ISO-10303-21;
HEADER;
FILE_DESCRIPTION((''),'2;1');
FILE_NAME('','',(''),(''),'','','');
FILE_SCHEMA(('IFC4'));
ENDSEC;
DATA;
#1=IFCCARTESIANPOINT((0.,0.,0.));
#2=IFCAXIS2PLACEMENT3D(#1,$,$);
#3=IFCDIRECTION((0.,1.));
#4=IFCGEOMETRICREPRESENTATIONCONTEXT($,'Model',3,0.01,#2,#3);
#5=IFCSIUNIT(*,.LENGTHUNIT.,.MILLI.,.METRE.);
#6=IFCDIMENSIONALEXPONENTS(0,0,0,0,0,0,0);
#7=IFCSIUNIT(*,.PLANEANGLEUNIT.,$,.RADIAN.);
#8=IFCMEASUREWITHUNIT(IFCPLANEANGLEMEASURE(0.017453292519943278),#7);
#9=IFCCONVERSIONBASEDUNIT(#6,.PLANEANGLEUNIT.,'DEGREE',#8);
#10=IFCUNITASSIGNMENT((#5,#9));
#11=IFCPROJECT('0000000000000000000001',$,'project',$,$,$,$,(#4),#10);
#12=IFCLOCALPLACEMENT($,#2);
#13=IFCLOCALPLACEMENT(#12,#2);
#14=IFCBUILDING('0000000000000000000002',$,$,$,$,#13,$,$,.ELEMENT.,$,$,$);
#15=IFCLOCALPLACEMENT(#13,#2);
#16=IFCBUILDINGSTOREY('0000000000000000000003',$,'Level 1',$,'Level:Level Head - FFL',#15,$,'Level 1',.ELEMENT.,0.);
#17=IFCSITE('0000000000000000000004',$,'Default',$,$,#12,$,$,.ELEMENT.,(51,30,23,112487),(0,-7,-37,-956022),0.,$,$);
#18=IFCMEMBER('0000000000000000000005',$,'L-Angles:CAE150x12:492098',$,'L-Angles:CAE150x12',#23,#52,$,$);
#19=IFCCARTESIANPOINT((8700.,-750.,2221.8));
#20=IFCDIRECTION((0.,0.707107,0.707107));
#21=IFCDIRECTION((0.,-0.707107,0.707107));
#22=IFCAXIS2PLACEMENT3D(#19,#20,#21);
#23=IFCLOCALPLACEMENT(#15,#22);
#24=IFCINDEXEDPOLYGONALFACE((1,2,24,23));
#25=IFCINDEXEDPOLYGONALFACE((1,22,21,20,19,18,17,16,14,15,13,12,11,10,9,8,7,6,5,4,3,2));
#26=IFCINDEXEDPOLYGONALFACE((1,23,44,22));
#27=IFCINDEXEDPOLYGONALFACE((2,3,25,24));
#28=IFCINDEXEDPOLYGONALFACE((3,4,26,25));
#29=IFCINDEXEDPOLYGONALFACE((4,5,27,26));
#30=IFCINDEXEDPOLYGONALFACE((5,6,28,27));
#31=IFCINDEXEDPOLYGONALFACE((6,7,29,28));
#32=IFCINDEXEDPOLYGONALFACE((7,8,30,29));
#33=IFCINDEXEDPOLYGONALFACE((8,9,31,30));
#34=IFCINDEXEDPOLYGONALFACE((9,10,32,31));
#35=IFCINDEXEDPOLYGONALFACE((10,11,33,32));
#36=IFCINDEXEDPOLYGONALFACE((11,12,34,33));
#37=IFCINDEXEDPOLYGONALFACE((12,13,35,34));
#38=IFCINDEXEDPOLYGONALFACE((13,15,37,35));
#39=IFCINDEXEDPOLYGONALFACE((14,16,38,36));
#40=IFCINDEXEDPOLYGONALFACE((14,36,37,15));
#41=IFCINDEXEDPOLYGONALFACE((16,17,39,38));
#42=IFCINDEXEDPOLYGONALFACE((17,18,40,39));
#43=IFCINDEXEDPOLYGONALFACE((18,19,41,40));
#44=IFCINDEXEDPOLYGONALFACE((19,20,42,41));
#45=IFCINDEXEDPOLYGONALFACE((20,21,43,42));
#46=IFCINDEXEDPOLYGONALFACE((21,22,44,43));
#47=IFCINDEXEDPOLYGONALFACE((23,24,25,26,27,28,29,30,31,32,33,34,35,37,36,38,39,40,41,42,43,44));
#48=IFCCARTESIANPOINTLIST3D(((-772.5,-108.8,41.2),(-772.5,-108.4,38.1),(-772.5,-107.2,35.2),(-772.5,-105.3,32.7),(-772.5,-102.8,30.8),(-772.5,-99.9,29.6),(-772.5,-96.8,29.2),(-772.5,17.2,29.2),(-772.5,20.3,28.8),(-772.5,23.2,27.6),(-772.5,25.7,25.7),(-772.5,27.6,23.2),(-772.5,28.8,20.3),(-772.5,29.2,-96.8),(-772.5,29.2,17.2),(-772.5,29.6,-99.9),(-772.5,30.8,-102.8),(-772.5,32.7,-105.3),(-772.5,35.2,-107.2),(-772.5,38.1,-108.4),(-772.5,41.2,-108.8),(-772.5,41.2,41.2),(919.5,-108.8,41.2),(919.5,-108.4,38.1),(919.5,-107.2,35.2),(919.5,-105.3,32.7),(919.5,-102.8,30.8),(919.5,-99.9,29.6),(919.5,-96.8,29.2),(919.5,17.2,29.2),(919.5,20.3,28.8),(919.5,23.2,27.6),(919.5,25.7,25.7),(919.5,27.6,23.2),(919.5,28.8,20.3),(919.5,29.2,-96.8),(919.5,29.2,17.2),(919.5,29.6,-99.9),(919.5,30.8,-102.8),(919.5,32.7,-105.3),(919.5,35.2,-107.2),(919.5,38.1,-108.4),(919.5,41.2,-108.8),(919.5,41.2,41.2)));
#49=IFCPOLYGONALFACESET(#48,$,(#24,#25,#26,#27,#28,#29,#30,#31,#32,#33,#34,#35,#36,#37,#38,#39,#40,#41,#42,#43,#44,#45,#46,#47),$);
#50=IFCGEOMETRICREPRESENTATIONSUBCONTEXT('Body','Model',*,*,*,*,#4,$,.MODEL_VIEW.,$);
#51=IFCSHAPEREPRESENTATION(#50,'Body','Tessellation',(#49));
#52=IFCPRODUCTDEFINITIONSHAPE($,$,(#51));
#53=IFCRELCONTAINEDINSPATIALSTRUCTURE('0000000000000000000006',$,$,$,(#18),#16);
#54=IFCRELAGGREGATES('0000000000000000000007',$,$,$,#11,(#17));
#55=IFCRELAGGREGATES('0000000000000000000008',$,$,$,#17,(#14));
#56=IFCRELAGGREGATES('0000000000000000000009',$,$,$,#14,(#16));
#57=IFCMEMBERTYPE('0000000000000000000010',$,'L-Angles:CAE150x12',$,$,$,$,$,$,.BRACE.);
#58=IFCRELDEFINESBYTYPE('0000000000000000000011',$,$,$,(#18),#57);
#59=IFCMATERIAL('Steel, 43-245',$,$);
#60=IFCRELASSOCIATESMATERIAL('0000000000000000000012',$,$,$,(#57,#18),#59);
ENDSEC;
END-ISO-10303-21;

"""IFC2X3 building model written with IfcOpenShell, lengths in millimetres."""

from ifc_helpers import new_model, entity, si_unit, converted_unit, direction, frame, frame_2d, origin, place, context, subcontext, project, spatial, polyline, circle_curve, parameter, trimmed, segment, composite_curve, outline, extrude, source, transform, mapped, material, type_object, type_shapes, element, save


model = new_model("IFC2X3")

# Units and contexts
model_context = context("Model", 3, precision=0.01, world=origin(), true_north=direction((0.0, 1.0)))
body_context = subcontext(model_context, "Body", "Model", "MODEL_VIEW")
ifc_project = project(units=[si_unit("LENGTHUNIT", "METRE", prefix="MILLI"), converted_unit("PLANEANGLEUNIT", "DEGREE", entity("IfcPlaneAngleMeasure", 0.017453292519943278), si_unit("PLANEANGLEUNIT", "RADIAN"), dimensions=[0, 0, 0, 0, 0, 0, 0])], contexts=[model_context])

# Site, building, storey
site_placement = place(None, origin())
site = spatial("IfcSite", under=ifc_project, at=site_placement, Name="Default", CompositionType="ELEMENT", RefLatitude=(51, 30, 23, 112487), RefLongitude=(0, -7, -37, -956022), RefElevation=0.0)
building_placement = place(site_placement, origin())
building = spatial("IfcBuilding", under=site, at=building_placement, CompositionType="ELEMENT")
storey_placement = place(building_placement, origin())
storey = spatial("IfcBuildingStorey", under=building, at=storey_placement, Name="Level 1", ObjectType="Level:Level Head - FFL", LongName="Level 1", CompositionType="ELEMENT", Elevation=0.0)

# Shared definitions
ifc_material = material(Name="Steel, 43-245")

# Member
member_type_1 = type_object("IfcMemberType", Name="L-Angles:CAE150x12", PredefinedType="BRACE", material=ifc_material)
shared_shape_1 = source(origin(), body_context, "Body", "SweptSolid", [
    extrude(outline(composite_curve([segment(polyline([(-102.0, -48.0), (48.0, -48.0)]), True, "CONTINUOUS"), segment(polyline([(48.0, -48.0), (48.0, 102.0)]), True, "CONTINUOUS"), segment(trimmed(circle_curve(frame_2d((48.0, 90.0), x_axis=(0.0, 1.0)), 12.0), [parameter(0.0)], [parameter(90.0)], True, "PARAMETER"), True, "CONTINUOUS"), segment(polyline([(36.0, 90.0), (36.0, -24.0)]), True, "CONTINUOUS"), segment(trimmed(circle_curve(frame_2d((24.0, -24.0), x_axis=(1.0, 0.0)), 12.0), [parameter(270.0)], [parameter(0.0)], True, "PARAMETER"), False, "CONTINUOUS"), segment(polyline([(24.0, -36.0), (-90.0, -36.0)]), True, "CONTINUOUS"), segment(trimmed(circle_curve(frame_2d((-90.0, -48.0), x_axis=(0.0, 1.0)), 12.0), [parameter(0.0)], [parameter(90.0)], True, "PARAMETER"), True, "CONTINUOUS")], self_intersect=False)), frame((-772.5, -6.8, -6.8), z_axis=(1.0, 0.0, 0.0), x_axis=(0.0, 0.0, 1.0)), (0.0, 0.0, 1.0), 1692.0),
])
type_shapes(member_type_1, [shared_shape_1])
member_1_placement = place(storey_placement, frame((8700.0, -750.0, 2221.8), z_axis=(0.0, 0.707107, 0.707107), x_axis=(0.0, -0.707107, 0.707107)))
element("IfcMember", 1, at=member_1_placement, inside=storey, type_object=member_type_1, material=ifc_material, Name="L-Angles:CAE150x12:492098", ObjectType="L-Angles:CAE150x12", context=body_context, shape_type="MappedRepresentation", body=[
    mapped(shared_shape_1, transform((0.0, 0.0, 0.0), scale=1.0)),
])

save(model, "model.ifc")
